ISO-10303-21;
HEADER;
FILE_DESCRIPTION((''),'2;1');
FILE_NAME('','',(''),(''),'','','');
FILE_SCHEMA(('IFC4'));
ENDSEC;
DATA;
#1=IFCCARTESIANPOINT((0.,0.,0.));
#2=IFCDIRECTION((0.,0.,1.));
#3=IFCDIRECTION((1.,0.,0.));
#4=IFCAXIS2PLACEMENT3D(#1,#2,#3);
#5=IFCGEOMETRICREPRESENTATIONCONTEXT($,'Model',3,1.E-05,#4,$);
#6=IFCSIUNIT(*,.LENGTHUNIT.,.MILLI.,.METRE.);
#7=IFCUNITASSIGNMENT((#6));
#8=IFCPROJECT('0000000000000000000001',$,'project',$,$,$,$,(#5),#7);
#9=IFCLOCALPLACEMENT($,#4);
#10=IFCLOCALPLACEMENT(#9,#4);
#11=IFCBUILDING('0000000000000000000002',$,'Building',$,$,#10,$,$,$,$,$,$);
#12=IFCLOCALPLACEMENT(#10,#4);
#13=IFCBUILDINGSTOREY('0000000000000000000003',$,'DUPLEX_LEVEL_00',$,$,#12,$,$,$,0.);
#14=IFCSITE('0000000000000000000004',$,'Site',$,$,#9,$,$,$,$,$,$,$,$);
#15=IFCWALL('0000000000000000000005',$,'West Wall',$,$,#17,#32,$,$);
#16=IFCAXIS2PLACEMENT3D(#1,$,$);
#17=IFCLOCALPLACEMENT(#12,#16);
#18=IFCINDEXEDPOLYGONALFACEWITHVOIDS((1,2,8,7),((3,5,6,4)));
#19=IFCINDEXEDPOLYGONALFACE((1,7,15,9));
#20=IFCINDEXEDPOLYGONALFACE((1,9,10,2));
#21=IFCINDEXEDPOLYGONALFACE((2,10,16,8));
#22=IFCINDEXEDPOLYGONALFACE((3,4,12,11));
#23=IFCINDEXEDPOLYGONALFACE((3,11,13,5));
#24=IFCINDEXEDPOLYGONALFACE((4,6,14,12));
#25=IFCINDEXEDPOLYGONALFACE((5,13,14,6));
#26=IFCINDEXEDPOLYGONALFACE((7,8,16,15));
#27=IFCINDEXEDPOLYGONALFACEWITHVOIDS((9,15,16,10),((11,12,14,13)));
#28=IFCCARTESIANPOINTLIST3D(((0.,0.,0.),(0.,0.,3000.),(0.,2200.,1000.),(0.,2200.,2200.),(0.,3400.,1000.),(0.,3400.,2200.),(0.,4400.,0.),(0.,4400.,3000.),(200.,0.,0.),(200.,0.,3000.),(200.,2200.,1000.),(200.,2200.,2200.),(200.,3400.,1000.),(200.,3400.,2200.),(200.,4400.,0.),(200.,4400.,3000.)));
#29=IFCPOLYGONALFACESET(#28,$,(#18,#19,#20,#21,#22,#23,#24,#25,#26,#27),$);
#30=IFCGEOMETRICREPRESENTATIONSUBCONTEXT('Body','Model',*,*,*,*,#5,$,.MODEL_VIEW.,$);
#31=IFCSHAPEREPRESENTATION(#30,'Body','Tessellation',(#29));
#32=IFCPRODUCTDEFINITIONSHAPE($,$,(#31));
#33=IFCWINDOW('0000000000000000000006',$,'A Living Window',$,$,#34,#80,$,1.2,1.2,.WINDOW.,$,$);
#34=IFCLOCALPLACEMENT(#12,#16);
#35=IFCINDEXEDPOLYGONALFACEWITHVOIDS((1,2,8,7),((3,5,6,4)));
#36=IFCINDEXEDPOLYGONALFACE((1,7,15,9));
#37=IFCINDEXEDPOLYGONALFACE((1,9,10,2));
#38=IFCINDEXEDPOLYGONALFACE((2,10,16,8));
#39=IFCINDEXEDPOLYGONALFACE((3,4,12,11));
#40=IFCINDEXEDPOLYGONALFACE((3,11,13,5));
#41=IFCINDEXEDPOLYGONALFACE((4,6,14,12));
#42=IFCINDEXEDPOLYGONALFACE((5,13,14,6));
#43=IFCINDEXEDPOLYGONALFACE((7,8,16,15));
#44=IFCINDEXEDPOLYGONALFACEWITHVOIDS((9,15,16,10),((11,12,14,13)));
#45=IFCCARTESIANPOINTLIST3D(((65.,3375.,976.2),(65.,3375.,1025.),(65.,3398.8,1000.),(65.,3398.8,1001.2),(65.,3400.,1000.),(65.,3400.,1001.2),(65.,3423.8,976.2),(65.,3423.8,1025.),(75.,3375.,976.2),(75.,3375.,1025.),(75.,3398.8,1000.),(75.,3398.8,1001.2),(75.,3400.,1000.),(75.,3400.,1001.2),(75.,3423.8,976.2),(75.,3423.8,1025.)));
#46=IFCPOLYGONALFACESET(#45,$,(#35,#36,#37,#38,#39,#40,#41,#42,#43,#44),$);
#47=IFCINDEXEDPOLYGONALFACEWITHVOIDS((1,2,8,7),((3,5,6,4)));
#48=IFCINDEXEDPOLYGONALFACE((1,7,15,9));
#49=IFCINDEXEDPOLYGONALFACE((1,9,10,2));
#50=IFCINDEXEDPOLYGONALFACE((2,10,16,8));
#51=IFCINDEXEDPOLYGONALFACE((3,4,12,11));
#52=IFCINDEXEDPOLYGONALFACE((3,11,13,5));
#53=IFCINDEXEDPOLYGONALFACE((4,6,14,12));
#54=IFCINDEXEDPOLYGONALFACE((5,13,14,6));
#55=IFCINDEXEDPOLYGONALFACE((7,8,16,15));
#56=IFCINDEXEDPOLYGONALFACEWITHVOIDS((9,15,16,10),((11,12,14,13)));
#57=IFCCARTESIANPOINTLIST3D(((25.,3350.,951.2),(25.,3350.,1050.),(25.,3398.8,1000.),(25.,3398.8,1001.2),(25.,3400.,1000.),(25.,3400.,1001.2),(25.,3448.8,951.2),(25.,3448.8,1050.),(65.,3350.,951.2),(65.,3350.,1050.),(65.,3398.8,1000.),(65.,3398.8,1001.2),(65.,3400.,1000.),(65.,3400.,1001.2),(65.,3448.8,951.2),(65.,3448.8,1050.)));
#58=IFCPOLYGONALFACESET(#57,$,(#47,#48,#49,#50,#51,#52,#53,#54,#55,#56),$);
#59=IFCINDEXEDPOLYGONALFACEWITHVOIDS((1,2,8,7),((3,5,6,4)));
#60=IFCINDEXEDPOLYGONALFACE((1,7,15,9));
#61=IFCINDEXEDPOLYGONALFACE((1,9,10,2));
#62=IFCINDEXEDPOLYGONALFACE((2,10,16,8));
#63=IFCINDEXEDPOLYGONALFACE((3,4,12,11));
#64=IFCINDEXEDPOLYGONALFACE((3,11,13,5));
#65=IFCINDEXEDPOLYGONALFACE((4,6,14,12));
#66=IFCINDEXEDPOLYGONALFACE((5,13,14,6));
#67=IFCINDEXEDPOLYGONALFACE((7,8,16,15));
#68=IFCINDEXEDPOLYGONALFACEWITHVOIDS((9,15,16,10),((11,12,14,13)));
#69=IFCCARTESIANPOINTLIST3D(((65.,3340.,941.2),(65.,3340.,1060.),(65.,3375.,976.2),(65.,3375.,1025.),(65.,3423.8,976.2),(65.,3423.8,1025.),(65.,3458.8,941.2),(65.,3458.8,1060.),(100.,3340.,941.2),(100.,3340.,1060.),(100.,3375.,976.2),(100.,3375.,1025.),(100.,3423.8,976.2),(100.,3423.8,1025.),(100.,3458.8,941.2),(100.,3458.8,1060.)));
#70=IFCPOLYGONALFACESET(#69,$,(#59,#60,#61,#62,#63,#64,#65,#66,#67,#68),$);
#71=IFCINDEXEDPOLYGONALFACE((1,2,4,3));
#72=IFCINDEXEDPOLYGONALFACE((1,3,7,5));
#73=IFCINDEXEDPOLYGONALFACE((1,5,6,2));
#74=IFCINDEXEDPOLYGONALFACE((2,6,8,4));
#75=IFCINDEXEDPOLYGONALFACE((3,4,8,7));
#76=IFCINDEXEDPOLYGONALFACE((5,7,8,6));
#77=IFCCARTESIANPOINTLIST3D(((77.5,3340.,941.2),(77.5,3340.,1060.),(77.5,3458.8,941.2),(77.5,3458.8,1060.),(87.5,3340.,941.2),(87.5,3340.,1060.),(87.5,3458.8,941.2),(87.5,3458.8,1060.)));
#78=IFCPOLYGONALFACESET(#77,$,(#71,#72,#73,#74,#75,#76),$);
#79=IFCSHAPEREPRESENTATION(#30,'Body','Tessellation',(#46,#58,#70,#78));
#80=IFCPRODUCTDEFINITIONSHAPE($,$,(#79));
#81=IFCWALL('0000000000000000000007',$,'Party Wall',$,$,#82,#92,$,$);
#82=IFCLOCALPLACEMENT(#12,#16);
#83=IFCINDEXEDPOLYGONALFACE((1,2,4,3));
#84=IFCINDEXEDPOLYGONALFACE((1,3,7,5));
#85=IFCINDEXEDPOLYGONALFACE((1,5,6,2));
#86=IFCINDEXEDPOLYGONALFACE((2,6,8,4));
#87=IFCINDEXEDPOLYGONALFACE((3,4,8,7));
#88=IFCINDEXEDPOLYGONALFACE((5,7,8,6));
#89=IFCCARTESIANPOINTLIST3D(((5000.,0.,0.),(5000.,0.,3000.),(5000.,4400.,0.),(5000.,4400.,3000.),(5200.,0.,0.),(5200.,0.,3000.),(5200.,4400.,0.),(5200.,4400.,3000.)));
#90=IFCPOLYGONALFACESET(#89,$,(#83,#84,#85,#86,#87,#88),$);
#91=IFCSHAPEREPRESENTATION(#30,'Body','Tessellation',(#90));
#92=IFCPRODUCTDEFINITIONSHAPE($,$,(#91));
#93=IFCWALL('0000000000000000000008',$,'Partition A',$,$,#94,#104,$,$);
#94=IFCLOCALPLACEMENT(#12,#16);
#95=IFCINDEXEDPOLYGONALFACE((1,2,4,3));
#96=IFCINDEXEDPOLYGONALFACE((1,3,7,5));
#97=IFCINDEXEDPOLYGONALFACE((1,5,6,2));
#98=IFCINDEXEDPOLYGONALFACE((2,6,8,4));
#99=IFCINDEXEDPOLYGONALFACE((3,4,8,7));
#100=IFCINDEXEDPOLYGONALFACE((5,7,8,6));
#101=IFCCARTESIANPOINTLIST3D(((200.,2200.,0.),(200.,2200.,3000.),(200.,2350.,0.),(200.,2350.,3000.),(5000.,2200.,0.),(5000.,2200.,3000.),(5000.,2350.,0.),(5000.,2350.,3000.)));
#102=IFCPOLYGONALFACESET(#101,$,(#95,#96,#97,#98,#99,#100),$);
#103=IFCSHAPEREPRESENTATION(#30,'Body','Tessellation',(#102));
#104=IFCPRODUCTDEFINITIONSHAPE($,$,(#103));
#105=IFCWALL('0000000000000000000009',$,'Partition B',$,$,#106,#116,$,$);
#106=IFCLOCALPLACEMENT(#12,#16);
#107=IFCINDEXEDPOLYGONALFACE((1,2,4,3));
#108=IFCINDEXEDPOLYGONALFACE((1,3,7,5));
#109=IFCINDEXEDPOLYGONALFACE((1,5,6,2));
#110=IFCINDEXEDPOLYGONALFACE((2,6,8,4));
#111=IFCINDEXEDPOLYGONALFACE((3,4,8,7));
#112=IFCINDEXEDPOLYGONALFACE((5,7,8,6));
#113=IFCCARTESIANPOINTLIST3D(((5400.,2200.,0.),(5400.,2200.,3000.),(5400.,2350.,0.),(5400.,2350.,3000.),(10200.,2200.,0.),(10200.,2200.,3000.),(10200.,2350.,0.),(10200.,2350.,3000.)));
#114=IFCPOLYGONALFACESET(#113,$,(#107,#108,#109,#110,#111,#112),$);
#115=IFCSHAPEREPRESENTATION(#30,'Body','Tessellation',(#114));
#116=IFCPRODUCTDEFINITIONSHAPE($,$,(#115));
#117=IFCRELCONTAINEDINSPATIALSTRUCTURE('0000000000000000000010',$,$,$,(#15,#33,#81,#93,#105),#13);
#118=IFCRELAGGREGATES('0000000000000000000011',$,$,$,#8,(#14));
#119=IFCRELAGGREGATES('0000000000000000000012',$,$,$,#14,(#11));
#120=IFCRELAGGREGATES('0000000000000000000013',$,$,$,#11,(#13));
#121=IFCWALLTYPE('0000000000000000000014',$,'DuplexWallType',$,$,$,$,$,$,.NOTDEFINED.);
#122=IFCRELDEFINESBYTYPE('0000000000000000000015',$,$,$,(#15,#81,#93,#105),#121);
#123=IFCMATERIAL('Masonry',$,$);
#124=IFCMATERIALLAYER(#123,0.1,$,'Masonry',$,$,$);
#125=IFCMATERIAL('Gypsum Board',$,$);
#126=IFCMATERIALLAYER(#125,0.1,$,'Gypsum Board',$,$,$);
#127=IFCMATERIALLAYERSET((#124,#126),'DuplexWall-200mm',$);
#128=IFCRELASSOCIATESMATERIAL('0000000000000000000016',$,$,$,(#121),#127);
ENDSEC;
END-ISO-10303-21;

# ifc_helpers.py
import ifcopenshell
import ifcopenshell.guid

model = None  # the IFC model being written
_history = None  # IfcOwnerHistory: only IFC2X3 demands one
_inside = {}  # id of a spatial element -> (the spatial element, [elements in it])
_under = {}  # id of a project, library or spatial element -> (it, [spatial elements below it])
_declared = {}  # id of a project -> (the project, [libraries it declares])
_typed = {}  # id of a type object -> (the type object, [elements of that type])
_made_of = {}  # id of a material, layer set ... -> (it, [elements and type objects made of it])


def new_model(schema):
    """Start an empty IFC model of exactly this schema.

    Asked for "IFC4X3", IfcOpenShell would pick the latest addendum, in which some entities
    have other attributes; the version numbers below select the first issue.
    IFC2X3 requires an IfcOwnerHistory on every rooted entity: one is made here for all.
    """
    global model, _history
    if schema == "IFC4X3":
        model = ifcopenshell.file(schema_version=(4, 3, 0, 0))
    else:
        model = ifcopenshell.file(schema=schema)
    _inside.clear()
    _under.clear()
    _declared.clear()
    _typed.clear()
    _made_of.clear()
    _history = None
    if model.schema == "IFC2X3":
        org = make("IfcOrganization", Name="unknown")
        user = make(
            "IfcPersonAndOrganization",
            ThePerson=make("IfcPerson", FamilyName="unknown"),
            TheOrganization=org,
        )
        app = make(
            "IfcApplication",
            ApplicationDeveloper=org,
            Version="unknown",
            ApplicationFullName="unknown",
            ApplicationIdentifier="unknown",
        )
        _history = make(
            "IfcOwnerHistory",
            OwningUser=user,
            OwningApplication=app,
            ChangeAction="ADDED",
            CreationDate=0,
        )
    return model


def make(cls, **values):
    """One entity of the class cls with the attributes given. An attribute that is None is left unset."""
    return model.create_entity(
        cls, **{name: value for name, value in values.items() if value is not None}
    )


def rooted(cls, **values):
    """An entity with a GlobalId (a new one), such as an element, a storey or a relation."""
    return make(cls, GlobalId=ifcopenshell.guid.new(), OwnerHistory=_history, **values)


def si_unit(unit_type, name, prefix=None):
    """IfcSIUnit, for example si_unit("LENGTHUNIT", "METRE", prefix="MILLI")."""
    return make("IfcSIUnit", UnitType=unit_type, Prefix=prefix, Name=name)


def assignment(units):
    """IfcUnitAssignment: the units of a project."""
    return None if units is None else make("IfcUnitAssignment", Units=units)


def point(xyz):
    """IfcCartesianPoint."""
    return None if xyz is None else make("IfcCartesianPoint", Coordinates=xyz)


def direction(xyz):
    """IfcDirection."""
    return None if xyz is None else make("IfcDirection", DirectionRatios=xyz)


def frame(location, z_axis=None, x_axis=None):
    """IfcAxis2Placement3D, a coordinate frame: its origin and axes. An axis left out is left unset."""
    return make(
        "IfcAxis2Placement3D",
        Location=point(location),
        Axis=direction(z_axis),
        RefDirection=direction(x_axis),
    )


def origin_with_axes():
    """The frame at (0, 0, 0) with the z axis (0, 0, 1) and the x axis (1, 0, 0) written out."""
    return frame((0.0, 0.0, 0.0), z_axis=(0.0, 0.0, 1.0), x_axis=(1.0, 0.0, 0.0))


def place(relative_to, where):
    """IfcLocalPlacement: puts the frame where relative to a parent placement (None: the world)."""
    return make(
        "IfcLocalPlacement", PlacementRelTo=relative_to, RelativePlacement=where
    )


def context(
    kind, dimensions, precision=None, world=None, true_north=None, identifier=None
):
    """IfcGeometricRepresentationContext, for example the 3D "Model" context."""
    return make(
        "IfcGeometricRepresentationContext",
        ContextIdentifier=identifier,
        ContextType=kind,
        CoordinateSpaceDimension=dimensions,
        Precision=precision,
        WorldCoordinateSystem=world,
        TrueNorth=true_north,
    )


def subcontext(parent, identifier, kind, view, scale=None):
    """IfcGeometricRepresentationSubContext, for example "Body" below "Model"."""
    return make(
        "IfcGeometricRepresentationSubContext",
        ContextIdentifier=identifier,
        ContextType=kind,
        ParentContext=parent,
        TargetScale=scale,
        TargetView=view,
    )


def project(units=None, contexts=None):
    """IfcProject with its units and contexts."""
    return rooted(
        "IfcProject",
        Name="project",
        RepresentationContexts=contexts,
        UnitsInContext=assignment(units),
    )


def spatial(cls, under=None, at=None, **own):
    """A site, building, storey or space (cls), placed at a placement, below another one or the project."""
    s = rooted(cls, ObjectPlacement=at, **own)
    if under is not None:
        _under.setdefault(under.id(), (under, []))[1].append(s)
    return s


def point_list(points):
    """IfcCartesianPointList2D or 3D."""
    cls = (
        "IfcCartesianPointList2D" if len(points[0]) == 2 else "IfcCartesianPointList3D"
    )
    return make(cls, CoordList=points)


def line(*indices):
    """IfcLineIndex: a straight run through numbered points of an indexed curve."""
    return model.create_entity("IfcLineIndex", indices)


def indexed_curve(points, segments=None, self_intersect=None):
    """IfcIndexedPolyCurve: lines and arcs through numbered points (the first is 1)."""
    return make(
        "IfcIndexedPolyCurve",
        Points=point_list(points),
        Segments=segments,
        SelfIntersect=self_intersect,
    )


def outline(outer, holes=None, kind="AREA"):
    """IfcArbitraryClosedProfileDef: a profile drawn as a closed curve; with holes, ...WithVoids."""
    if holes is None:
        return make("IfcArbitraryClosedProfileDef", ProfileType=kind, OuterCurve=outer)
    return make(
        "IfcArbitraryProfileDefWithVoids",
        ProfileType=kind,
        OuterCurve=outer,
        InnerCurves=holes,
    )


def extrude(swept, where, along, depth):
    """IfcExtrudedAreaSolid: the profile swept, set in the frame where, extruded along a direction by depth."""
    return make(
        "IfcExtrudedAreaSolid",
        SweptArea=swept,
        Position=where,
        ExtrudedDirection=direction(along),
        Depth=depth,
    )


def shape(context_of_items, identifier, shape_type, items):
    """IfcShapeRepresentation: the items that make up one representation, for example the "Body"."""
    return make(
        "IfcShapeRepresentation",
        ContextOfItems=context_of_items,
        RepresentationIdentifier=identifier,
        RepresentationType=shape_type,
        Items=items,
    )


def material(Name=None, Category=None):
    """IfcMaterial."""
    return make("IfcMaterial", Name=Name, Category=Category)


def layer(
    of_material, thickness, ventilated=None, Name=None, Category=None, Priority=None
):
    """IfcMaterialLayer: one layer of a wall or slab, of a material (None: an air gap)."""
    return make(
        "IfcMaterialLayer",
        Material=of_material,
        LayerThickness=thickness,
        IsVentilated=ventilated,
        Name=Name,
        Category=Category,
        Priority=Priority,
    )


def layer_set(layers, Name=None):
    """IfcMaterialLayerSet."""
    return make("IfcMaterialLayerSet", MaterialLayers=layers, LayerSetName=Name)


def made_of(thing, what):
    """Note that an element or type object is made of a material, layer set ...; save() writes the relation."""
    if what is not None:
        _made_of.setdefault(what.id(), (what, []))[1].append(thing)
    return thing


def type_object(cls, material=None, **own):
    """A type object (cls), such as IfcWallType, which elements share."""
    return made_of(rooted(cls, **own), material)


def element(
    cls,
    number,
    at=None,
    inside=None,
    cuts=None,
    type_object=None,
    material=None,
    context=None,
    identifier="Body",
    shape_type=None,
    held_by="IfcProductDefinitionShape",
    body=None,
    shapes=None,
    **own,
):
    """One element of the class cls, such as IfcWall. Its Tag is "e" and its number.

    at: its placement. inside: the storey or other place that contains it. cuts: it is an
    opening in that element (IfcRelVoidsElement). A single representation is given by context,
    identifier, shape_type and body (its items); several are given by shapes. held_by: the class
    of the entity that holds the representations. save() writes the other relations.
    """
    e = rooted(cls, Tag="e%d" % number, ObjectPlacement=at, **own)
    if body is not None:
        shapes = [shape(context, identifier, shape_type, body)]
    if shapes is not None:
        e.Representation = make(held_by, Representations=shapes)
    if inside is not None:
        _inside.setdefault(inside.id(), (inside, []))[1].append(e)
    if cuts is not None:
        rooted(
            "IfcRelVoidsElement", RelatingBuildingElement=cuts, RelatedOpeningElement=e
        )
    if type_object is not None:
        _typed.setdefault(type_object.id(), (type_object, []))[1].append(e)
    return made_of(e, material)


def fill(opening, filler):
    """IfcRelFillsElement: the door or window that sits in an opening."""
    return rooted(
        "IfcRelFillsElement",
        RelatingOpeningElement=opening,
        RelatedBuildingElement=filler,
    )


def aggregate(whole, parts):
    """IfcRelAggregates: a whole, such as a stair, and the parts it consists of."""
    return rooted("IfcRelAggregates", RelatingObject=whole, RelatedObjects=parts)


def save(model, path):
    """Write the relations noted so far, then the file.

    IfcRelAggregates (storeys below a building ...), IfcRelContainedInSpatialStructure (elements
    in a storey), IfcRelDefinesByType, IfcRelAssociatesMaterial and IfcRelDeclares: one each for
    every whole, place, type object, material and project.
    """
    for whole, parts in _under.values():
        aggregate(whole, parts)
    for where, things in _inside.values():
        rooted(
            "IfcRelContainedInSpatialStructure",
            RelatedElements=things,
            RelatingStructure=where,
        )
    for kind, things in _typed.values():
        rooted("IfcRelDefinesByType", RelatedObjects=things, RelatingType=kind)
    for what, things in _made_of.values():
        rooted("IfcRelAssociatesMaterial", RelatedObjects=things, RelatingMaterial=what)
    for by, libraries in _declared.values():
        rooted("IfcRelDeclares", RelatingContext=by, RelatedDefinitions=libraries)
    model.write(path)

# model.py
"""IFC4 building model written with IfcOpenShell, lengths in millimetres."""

from ifc_helpers import new_model, si_unit, frame, origin_with_axes, place, context, subcontext, project, spatial, line, indexed_curve, outline, extrude, material, layer, layer_set, type_object, element, fill, save


model = new_model("IFC4")

# Units and contexts
model_context = context("Model", 3, precision=1e-05, world=origin_with_axes())
body_context = subcontext(model_context, "Body", "Model", "MODEL_VIEW")
ifc_project = project(units=[si_unit("LENGTHUNIT", "METRE", prefix="MILLI")], contexts=[model_context])

# Site, building, storey
site_placement = place(None, origin_with_axes())
site = spatial("IfcSite", under=ifc_project, at=site_placement, Name="Site")
building_placement = place(site_placement, origin_with_axes())
building = spatial("IfcBuilding", under=site, at=building_placement, Name="Building")
storey_placement = place(building_placement, origin_with_axes())
storey = spatial("IfcBuildingStorey", under=building, at=storey_placement, Name="DUPLEX_LEVEL_00", Elevation=0.0)

# Shared definitions
ifc_material_1 = material(Name="Masonry")
ifc_layer_1 = layer(ifc_material_1, 0.1, Name="Masonry")
ifc_material_2 = material(Name="Gypsum Board")
ifc_layer_2 = layer(ifc_material_2, 0.1, Name="Gypsum Board")
ifc_layer_set = layer_set([ifc_layer_1, ifc_layer_2], Name="DuplexWall-200mm")
wall_type = type_object("IfcWallType", Name="DuplexWallType", PredefinedType="NOTDEFINED", material=ifc_layer_set)

# Wall, opening, window
wall_1_placement = place(storey_placement, frame((0.0, 4400.0, 0.0), z_axis=(0.0, 0.0, 1.0), x_axis=(0.0, -1.0, 0.0)))
wall_1 = element("IfcWall", 1, at=wall_1_placement, inside=storey, type_object=wall_type, Name="West Wall", context=body_context, shape_type="SweptSolid", body=[
    extrude(outline(indexed_curve([(0.0, 0.0), (0.0, 200.0), (4400.0, 200.0), (4400.0, 0.0), (0.0, 0.0)], self_intersect=False)), origin_with_axes(), (0.0, 0.0, 1.0), 3000.0),
])
opening_1_placement = place(wall_1_placement, frame((1000.0, -25.0, 1000.0), z_axis=(0.0, 0.0, 1.0), x_axis=(1.0, 0.0, 0.0)))
opening_1 = element("IfcOpeningElement", 2, at=opening_1_placement, cuts=wall_1, context=body_context, shape_type="SweptSolid", body=[
    extrude(outline(indexed_curve([(0.0, 0.0), (0.0, 250.0), (1200.0, 250.0), (1200.0, 0.0), (0.0, 0.0)], self_intersect=False)), origin_with_axes(), (0.0, 0.0, 1.0), 1200.0),
])
window_1_placement = place(storey_placement, frame((-25.0, 3400.0, 1000.0), z_axis=(0.0, 0.0, 1.0), x_axis=(0.0, -1.0, 0.0)))
window_1 = element("IfcWindow", 3, at=window_1_placement, inside=storey, Name="A Living Window", OverallHeight=1.2, OverallWidth=1.2, PredefinedType="WINDOW", context=body_context, shape_type="SweptSolid", body=[
    extrude(outline(indexed_curve([(0.0, 0.0), (1.2, 0.0), (1.2, 1.2), (0.0, 1.2)], segments=[line(1, 2, 3, 4, 1)]), holes=[indexed_curve([(25.0, 25.0), (-23.8, 25.0), (-23.8, -23.8), (25.0, -23.8)], segments=[line(1, 2, 3, 4, 1)])]), frame((0.0, 90.0, 0.0), z_axis=(0.0, -1.0, 0.0), x_axis=(1.0, 0.0, 0.0)), (0.0, 0.0, -1.0), 10.0),
    extrude(outline(indexed_curve([(0.0, 0.0), (1.2, 0.0), (1.2, 1.2), (0.0, 1.2)], segments=[line(1, 2, 3, 4, 1)]), holes=[indexed_curve([(50.0, 50.0), (-48.8, 50.0), (-48.8, -48.8), (50.0, -48.8)], segments=[line(1, 2, 3, 4, 1)])]), frame((0.0, 50.0, 0.0), z_axis=(0.0, -1.0, 0.0), x_axis=(1.0, 0.0, 0.0)), (0.0, 0.0, -1.0), 40.0),
    extrude(outline(indexed_curve([(0.0, 0.0), (-48.8, 0.0), (-48.8, -48.8), (0.0, -48.8)], segments=[line(1, 2, 3, 4, 1)]), holes=[indexed_curve([(35.0, 35.0), (-83.8, 35.0), (-83.8, -83.8), (35.0, -83.8)], segments=[line(1, 2, 3, 4, 1)])]), frame((25.0, 90.0, 25.0), z_axis=(0.0, -1.0, 0.0), x_axis=(1.0, 0.0, 0.0)), (0.0, 0.0, -1.0), 35.0),
    extrude(outline(indexed_curve([(35.0, 35.0), (-83.8, 35.0), (-83.8, -83.8), (35.0, -83.8)], segments=[line(1, 2, 3, 4, 1)])), frame((25.0, 102.5, 25.0), z_axis=(0.0, -1.0, 0.0), x_axis=(1.0, 0.0, 0.0)), (0.0, 0.0, -1.0), 10.0),
])
fill(opening_1, window_1)

# Walls
wall_2_placement = place(storey_placement, frame((5200.0, 0.0, 0.0), z_axis=(0.0, 0.0, 1.0), x_axis=(0.0, 1.0, 0.0)))
element("IfcWall", 4, at=wall_2_placement, inside=storey, type_object=wall_type, Name="Party Wall", context=body_context, shape_type="SweptSolid", body=[
    extrude(outline(indexed_curve([(0.0, 0.0), (0.0, 200.0), (4400.0, 200.0), (4400.0, 0.0), (0.0, 0.0)], self_intersect=False)), origin_with_axes(), (0.0, 0.0, 1.0), 3000.0),
])
wall_3_placement = place(storey_placement, frame((200.0, 2200.0, 0.0), z_axis=(0.0, 0.0, 1.0), x_axis=(1.0, 0.0, 0.0)))
element("IfcWall", 5, at=wall_3_placement, inside=storey, type_object=wall_type, Name="Partition A", context=body_context, shape_type="SweptSolid", body=[
    extrude(outline(indexed_curve([(0.0, 0.0), (0.0, 150.0), (4800.0, 150.0), (4800.0, 0.0), (0.0, 0.0)], self_intersect=False)), origin_with_axes(), (0.0, 0.0, 1.0), 3000.0),
])
wall_4_placement = place(storey_placement, frame((5400.0, 2200.0, 0.0), z_axis=(0.0, 0.0, 1.0), x_axis=(1.0, 0.0, 0.0)))
element("IfcWall", 6, at=wall_4_placement, inside=storey, type_object=wall_type, Name="Partition B", context=body_context, shape_type="SweptSolid", body=[
    extrude(outline(indexed_curve([(0.0, 0.0), (0.0, 150.0), (4800.0, 150.0), (4800.0, 0.0), (0.0, 0.0)], self_intersect=False)), origin_with_axes(), (0.0, 0.0, 1.0), 3000.0),
])

save(model, "model.ifc")
